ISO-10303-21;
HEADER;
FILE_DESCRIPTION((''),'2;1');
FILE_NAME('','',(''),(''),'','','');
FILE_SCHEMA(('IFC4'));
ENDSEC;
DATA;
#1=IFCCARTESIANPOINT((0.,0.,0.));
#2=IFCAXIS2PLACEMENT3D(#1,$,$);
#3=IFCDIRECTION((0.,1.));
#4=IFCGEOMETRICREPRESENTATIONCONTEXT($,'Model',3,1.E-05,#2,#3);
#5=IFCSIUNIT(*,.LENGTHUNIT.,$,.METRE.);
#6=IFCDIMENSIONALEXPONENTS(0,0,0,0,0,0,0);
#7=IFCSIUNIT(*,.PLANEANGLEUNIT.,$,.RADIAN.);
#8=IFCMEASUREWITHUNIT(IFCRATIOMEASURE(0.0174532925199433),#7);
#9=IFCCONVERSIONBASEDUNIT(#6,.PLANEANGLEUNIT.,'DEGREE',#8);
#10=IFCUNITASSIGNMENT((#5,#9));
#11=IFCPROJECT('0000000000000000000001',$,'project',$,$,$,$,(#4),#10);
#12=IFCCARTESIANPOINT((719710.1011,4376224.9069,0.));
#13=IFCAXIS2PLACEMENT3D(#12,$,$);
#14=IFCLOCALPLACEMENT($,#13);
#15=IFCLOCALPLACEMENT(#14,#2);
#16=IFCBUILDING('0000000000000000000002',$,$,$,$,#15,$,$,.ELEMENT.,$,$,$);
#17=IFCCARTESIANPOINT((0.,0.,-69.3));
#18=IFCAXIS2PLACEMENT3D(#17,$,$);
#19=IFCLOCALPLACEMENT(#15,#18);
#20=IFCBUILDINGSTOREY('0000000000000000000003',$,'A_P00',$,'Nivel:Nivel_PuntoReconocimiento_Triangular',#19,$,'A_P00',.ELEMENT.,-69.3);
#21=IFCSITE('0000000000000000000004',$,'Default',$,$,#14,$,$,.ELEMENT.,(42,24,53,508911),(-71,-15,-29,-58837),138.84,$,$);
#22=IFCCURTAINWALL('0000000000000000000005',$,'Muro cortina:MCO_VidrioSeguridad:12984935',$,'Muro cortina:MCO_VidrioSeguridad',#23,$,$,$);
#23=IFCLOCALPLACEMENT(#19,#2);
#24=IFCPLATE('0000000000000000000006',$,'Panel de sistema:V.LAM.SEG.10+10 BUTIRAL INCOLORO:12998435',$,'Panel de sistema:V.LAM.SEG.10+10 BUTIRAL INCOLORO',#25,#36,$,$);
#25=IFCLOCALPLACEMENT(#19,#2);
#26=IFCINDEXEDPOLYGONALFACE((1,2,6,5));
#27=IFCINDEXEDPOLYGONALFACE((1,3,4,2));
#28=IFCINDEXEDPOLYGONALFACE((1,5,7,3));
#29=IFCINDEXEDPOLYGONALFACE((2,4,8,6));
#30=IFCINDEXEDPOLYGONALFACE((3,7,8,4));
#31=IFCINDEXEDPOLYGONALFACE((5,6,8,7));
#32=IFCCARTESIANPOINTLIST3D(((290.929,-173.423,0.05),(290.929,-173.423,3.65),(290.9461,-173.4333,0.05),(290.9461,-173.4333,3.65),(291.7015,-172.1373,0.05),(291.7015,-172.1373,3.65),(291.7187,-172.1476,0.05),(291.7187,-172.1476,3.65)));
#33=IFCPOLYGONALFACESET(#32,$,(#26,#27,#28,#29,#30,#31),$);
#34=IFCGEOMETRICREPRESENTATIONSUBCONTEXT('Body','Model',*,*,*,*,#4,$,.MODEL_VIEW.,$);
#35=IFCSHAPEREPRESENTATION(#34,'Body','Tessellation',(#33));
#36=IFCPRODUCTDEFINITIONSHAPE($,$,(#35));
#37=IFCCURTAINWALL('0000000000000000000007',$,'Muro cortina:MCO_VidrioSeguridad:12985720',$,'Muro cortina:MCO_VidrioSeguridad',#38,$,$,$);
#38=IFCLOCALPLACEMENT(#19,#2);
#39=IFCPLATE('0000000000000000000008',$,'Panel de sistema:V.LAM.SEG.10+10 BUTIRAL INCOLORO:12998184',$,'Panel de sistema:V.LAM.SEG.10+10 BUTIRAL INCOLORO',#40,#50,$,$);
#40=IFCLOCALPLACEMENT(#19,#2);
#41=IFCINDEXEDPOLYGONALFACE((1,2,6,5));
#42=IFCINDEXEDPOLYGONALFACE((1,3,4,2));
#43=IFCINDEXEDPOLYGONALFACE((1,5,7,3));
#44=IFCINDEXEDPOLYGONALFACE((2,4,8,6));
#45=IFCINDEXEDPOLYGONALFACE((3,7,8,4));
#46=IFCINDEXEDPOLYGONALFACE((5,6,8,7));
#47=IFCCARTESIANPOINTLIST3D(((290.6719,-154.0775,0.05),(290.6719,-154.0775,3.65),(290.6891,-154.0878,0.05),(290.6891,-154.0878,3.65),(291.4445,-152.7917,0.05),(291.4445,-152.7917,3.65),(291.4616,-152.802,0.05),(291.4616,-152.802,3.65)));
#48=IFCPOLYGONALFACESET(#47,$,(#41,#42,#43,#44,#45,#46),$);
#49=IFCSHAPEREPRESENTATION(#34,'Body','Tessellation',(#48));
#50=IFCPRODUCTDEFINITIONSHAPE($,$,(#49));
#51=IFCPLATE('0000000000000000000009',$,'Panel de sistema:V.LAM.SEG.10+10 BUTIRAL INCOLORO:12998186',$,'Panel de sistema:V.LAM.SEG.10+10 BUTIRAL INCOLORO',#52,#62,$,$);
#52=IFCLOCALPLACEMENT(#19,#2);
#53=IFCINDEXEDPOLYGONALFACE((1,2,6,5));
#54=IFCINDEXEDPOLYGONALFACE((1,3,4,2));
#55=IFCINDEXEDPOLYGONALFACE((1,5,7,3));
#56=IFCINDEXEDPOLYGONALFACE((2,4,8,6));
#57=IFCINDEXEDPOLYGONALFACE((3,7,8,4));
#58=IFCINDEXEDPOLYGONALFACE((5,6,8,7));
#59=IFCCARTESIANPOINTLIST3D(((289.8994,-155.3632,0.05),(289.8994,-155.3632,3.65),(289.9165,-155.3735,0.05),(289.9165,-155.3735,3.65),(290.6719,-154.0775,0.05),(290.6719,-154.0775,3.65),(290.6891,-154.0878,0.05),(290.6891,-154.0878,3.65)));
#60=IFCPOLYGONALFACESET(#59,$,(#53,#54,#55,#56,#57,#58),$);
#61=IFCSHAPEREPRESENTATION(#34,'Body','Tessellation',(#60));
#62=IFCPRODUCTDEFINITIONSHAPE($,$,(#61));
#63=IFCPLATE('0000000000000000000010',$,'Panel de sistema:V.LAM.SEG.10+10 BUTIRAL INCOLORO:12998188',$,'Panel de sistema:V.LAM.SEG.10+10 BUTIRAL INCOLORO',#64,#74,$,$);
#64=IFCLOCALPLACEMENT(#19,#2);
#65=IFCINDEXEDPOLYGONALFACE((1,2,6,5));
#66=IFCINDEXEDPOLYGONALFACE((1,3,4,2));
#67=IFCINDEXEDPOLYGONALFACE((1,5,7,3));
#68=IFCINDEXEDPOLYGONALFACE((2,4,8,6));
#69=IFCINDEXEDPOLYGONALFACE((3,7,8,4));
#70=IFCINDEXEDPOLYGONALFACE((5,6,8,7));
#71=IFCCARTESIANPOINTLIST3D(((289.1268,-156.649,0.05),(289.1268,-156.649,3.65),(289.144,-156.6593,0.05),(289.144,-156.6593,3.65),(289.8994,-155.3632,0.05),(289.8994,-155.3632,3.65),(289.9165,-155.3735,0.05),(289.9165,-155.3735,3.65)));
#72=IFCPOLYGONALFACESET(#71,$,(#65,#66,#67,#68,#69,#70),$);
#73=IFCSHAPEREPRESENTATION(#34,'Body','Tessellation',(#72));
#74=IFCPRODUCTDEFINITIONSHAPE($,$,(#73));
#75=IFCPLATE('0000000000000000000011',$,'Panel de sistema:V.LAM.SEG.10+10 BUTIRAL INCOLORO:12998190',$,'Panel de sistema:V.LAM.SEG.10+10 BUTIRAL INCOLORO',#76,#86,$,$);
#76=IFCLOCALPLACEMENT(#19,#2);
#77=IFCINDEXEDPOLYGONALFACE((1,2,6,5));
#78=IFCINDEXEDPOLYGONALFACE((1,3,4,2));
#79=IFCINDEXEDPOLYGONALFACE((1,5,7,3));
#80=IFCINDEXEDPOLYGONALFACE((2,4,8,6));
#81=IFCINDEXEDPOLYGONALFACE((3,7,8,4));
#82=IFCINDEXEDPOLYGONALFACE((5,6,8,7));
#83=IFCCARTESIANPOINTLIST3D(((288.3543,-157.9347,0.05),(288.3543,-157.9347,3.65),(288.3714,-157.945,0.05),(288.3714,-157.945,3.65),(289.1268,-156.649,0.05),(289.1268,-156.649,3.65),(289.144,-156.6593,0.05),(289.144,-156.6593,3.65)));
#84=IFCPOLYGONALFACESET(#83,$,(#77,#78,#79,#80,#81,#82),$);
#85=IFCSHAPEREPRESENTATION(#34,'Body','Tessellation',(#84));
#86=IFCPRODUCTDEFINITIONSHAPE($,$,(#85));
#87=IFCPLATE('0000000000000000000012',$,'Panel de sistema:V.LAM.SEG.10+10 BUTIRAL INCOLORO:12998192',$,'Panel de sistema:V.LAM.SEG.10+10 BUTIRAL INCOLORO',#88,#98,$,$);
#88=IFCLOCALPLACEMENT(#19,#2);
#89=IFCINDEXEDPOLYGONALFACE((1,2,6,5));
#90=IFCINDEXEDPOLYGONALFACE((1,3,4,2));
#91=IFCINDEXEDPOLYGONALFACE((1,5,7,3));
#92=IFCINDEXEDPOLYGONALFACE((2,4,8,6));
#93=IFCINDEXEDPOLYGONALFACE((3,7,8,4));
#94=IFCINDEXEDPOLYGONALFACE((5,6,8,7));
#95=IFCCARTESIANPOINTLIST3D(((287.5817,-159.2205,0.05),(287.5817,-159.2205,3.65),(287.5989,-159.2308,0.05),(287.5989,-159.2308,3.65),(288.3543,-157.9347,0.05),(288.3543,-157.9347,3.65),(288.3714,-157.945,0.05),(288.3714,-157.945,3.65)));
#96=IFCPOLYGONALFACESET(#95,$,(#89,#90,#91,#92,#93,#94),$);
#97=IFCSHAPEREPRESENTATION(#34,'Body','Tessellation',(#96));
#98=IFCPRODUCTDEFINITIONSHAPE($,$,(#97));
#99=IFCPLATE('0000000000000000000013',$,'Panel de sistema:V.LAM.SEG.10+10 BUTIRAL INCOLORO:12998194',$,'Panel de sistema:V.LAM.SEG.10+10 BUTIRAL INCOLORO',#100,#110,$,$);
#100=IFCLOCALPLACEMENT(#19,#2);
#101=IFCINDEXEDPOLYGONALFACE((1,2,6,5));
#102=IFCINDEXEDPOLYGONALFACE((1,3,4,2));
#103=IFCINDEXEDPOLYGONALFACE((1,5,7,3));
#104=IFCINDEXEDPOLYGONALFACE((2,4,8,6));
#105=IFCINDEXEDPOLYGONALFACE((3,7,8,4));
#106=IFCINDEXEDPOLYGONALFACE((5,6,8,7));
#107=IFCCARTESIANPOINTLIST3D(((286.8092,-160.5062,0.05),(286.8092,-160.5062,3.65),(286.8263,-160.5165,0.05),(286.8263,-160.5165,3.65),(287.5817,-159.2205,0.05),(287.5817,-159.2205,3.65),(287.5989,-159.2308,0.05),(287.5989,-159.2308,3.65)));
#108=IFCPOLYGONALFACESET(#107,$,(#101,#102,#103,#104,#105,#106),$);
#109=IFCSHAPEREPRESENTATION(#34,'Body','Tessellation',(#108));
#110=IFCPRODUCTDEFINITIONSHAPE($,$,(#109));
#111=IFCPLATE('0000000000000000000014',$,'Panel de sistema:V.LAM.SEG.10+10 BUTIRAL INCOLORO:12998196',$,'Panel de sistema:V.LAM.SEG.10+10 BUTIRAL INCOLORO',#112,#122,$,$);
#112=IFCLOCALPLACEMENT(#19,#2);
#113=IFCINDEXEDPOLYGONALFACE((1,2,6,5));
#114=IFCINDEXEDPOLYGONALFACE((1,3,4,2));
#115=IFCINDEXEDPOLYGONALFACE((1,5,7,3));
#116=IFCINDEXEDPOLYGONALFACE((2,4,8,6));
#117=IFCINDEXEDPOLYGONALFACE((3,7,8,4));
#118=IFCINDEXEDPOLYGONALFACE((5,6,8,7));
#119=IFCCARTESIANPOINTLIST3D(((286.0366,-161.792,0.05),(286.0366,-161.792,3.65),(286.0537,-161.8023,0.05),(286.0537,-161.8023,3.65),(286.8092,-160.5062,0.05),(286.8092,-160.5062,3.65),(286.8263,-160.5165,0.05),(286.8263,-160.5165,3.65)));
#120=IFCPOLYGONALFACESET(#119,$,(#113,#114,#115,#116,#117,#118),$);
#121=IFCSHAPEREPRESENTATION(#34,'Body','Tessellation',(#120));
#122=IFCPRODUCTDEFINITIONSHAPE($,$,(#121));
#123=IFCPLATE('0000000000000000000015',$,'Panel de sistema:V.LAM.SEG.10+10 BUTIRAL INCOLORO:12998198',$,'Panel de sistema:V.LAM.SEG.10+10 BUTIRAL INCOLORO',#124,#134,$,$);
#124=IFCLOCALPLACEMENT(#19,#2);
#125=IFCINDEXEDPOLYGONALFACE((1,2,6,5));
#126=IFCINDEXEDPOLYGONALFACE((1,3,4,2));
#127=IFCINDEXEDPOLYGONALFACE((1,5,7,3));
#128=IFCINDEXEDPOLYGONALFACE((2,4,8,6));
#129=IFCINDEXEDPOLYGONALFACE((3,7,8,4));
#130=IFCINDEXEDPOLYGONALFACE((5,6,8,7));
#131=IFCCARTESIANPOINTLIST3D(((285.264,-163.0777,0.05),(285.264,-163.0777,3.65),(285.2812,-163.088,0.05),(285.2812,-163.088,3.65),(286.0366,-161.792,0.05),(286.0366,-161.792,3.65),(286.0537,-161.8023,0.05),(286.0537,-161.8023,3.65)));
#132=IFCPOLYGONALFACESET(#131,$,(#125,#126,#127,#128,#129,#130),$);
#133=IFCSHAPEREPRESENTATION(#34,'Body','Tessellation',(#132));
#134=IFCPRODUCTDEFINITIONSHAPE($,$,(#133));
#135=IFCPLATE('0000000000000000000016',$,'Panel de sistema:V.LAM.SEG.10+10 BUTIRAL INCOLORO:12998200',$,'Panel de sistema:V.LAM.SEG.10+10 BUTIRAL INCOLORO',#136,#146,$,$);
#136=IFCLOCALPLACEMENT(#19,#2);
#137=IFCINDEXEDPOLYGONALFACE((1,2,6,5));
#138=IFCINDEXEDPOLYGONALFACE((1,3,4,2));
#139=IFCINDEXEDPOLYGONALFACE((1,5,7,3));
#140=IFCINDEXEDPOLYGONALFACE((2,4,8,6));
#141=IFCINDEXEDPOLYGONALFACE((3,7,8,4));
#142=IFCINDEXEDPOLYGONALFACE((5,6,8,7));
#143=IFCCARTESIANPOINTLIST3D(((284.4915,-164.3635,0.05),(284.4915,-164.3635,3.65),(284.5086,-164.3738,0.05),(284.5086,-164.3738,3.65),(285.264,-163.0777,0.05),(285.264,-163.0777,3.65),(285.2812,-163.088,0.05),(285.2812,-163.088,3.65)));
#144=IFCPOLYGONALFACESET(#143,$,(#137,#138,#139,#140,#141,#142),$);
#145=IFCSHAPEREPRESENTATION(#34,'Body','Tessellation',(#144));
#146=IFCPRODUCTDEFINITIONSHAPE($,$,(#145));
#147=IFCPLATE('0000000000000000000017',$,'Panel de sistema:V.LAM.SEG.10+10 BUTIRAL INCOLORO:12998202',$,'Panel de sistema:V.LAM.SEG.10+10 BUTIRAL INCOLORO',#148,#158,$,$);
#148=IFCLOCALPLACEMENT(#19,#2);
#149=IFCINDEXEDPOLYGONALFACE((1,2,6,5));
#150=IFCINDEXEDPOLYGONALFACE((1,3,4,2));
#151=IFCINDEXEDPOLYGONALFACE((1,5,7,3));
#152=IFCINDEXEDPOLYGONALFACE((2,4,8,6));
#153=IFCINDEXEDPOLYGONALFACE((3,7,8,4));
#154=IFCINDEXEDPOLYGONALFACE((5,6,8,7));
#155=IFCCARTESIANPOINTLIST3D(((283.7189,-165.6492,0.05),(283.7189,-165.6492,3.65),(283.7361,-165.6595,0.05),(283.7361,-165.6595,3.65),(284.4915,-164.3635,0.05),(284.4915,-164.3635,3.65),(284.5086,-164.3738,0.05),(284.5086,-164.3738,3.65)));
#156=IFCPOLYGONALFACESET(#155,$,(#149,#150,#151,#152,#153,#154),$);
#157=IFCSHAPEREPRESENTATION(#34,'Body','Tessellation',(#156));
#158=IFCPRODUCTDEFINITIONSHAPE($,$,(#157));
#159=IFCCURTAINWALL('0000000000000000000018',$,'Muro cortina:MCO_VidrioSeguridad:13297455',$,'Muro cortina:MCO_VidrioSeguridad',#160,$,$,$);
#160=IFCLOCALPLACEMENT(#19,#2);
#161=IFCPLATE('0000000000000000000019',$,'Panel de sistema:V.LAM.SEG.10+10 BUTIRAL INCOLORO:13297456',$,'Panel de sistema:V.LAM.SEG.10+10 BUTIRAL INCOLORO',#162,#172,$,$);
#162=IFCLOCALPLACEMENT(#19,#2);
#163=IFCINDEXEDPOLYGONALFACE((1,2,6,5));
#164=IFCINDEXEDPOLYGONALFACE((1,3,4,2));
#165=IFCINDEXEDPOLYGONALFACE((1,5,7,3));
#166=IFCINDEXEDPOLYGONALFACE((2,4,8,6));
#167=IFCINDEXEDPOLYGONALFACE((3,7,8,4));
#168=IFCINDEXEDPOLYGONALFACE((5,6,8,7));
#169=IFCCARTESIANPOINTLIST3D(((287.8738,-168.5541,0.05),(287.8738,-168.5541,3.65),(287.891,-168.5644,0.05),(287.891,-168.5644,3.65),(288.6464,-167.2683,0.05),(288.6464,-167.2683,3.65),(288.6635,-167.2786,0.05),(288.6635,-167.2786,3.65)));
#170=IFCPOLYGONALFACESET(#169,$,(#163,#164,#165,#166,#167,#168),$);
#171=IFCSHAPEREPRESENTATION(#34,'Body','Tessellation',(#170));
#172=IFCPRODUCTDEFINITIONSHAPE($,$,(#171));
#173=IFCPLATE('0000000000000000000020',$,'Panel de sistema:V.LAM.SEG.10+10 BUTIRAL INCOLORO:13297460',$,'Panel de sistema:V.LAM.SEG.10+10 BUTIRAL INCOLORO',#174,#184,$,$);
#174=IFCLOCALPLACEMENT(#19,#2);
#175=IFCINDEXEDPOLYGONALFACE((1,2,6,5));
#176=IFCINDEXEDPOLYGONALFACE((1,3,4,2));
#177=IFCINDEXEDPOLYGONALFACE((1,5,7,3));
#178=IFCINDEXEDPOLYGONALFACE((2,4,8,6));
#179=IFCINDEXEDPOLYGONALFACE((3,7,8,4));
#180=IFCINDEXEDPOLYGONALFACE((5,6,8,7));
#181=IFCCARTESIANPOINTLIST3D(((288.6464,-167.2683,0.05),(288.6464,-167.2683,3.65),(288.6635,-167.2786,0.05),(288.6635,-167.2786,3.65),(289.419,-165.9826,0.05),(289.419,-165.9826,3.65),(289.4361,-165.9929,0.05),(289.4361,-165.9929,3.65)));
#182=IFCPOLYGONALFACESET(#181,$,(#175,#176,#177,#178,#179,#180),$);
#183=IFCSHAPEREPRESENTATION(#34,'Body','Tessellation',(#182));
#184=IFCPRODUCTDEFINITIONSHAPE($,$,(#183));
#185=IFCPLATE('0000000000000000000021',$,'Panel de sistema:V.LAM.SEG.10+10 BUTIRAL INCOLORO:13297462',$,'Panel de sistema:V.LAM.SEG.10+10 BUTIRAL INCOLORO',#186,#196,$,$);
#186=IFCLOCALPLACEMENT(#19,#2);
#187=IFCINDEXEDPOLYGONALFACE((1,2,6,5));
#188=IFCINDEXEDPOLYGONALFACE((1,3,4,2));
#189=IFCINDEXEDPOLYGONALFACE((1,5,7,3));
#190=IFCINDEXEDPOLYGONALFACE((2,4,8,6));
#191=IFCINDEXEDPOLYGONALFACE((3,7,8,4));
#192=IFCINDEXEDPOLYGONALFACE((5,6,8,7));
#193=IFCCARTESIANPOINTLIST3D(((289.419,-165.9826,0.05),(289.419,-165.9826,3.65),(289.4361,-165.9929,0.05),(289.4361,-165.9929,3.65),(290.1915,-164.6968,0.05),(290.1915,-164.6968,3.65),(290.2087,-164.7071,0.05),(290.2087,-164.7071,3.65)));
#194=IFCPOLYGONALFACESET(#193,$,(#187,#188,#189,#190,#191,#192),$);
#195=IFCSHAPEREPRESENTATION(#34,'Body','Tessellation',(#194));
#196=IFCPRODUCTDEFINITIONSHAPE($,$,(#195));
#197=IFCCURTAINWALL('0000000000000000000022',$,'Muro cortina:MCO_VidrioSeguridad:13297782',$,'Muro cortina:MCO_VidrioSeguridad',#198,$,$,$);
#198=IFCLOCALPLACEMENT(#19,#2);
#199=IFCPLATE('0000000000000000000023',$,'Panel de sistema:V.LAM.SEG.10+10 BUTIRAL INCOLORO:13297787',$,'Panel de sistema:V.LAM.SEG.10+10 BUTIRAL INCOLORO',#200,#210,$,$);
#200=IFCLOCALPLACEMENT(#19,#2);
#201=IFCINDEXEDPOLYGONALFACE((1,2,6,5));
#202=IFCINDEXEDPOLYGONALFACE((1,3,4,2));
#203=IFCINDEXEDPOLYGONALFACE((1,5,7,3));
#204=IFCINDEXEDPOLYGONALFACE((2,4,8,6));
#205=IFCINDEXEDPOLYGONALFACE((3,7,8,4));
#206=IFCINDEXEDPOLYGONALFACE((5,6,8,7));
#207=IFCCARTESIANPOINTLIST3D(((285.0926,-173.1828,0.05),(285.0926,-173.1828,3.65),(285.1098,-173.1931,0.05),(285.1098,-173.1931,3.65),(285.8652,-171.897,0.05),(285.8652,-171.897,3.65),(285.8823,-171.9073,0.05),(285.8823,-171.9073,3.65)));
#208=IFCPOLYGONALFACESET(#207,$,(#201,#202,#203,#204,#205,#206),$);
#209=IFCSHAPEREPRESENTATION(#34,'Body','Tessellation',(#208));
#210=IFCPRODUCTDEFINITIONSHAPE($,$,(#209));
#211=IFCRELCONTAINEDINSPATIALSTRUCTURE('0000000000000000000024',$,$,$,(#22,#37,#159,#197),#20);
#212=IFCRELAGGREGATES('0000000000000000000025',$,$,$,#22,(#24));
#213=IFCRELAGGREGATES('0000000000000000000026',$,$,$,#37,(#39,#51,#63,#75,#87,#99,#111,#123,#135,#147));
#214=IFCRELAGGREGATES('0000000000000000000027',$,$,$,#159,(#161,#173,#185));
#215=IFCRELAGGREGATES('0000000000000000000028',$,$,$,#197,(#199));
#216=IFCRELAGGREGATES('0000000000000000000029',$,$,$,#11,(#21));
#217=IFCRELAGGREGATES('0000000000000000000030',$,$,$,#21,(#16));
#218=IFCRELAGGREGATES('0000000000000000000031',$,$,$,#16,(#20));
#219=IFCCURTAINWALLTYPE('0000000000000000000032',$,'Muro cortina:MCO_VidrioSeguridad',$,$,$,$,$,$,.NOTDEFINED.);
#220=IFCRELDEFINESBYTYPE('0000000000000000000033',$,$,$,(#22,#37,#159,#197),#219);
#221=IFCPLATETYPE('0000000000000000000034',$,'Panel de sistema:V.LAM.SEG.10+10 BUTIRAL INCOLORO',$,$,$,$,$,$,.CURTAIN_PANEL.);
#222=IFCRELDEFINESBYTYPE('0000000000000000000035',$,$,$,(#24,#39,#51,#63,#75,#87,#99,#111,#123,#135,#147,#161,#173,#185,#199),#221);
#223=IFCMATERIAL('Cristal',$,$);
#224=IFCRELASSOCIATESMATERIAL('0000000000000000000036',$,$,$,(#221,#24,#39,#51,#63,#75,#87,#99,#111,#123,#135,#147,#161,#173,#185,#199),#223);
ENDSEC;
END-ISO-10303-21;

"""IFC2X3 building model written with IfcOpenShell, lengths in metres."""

from ifc_helpers import new_model, entity, si_unit, converted_unit, direction, frame, origin, origin_2d_with_axis, place, context, subcontext, project, spatial, rectangle, extrude, source, transform, mapped, material, type_object, type_shapes, element, aggregate, save


model = new_model("IFC2X3")

# Units and contexts
model_context = context("Model", 3, precision=1e-05, world=origin(), true_north=direction((0.0, 1.0)))
body_context = subcontext(model_context, "Body", "Model", "MODEL_VIEW")
ifc_project = project(units=[si_unit("LENGTHUNIT", "METRE"), converted_unit("PLANEANGLEUNIT", "DEGREE", entity("IfcRatioMeasure", 0.0174532925199433), si_unit("PLANEANGLEUNIT", "RADIAN"), dimensions=[0, 0, 0, 0, 0, 0, 0])], contexts=[model_context])

# Site, building, storey
site_placement = place(None, frame((719710.1011, 4376224.9069, 0.0)))
site = spatial("IfcSite", under=ifc_project, at=site_placement, Name="Default", CompositionType="ELEMENT", RefLatitude=(42, 24, 53, 508911), RefLongitude=(-71, -15, -29, -58837), RefElevation=138.84)
building_placement = place(site_placement, origin())
building = spatial("IfcBuilding", under=site, at=building_placement, CompositionType="ELEMENT")
storey_placement = place(building_placement, frame((0.0, 0.0, -69.3)))
storey = spatial("IfcBuildingStorey", under=building, at=storey_placement, Name="A_P00", ObjectType="Nivel:Nivel_PuntoReconocimiento_Triangular", LongName="A_P00", CompositionType="ELEMENT", Elevation=-69.3)

# Curtain wall, plate
curtain_wall_type = type_object("IfcCurtainWallType", Name="Muro cortina:MCO_VidrioSeguridad", PredefinedType="NOTDEFINED")
curtain_wall_1_placement = place(storey_placement, frame((0.0, 0.0, 69.3)))
curtain_wall_1 = element("IfcCurtainWall", 1, at=curtain_wall_1_placement, inside=storey, type_object=curtain_wall_type, Name="Muro cortina:MCO_VidrioSeguridad:12984935", ObjectType="Muro cortina:MCO_VidrioSeguridad")
ifc_material_1 = material(Name="Cristal")
plate_type_1 = type_object("IfcPlateType", Name="Panel de sistema:V.LAM.SEG.10+10 BUTIRAL INCOLORO", PredefinedType="CURTAIN_PANEL", material=ifc_material_1)
shared_shape_1 = source(origin(), body_context, "Body", "SweptSolid", [
    extrude(rectangle(XDim=0.02, YDim=1.5, at=origin_2d_with_axis()), frame((0.0, 0.0, 0.0), z_axis=(0.0, 0.0, 1.0), x_axis=(0.0, 1.0, 0.0)), (0.0, 0.0, 1.0), 3.6),
])
type_shapes(plate_type_1, [shared_shape_1])
plate_1_placement = place(curtain_wall_1_placement, frame((291.3238, -172.7853, -69.25), z_axis=(0.0, 0.0, 1.0), x_axis=(-0.515038, -0.857167, 0.0)))
plate_1 = element("IfcPlate", 2, at=plate_1_placement, type_object=plate_type_1, material=ifc_material_1, Name="Panel de sistema:V.LAM.SEG.10+10 BUTIRAL INCOLORO:12998435", ObjectType="Panel de sistema:V.LAM.SEG.10+10 BUTIRAL INCOLORO", context=body_context, shape_type="MappedRepresentation", body=[
    mapped(shared_shape_1, transform((0.0, 0.0, 0.0), scale=1.0)),
])
aggregate(curtain_wall_1, [plate_1])

# Curtain walls, plates
curtain_wall_2_placement = place(storey_placement, frame((0.0, 0.0, 69.3)))
curtain_wall_2 = element("IfcCurtainWall", 3, at=curtain_wall_2_placement, inside=storey, type_object=curtain_wall_type, Name="Muro cortina:MCO_VidrioSeguridad:12985720", ObjectType="Muro cortina:MCO_VidrioSeguridad")
plate_2_placement = place(curtain_wall_2_placement, frame((291.0668, -153.4397, -69.25), z_axis=(0.0, 0.0, 1.0), x_axis=(-0.515038, -0.857167, 0.0)))
plate_2 = element("IfcPlate", 4, at=plate_2_placement, type_object=plate_type_1, material=ifc_material_1, Name="Panel de sistema:V.LAM.SEG.10+10 BUTIRAL INCOLORO:12998184", ObjectType="Panel de sistema:V.LAM.SEG.10+10 BUTIRAL INCOLORO", context=body_context, shape_type="MappedRepresentation", body=[
    mapped(shared_shape_1, transform((0.0, 0.0, 0.0), scale=1.0)),
])
plate_3_placement = place(curtain_wall_2_placement, frame((290.2942, -154.7255, -69.25), z_axis=(0.0, 0.0, 1.0), x_axis=(-0.515038, -0.857167, 0.0)))
plate_3 = element("IfcPlate", 5, at=plate_3_placement, type_object=plate_type_1, material=ifc_material_1, Name="Panel de sistema:V.LAM.SEG.10+10 BUTIRAL INCOLORO:12998186", ObjectType="Panel de sistema:V.LAM.SEG.10+10 BUTIRAL INCOLORO", context=body_context, shape_type="MappedRepresentation", body=[
    mapped(shared_shape_1, transform((0.0, 0.0, 0.0), scale=1.0)),
])
plate_4_placement = place(curtain_wall_2_placement, frame((289.5217, -156.0112, -69.25), z_axis=(0.0, 0.0, 1.0), x_axis=(-0.515038, -0.857167, 0.0)))
plate_4 = element("IfcPlate", 6, at=plate_4_placement, type_object=plate_type_1, material=ifc_material_1, Name="Panel de sistema:V.LAM.SEG.10+10 BUTIRAL INCOLORO:12998188", ObjectType="Panel de sistema:V.LAM.SEG.10+10 BUTIRAL INCOLORO", context=body_context, shape_type="MappedRepresentation", body=[
    mapped(shared_shape_1, transform((0.0, 0.0, 0.0), scale=1.0)),
])
plate_5_placement = place(curtain_wall_2_placement, frame((288.7491, -157.297, -69.25), z_axis=(0.0, 0.0, 1.0), x_axis=(-0.515038, -0.857167, 0.0)))
plate_5 = element("IfcPlate", 7, at=plate_5_placement, type_object=plate_type_1, material=ifc_material_1, Name="Panel de sistema:V.LAM.SEG.10+10 BUTIRAL INCOLORO:12998190", ObjectType="Panel de sistema:V.LAM.SEG.10+10 BUTIRAL INCOLORO", context=body_context, shape_type="MappedRepresentation", body=[
    mapped(shared_shape_1, transform((0.0, 0.0, 0.0), scale=1.0)),
])
plate_6_placement = place(curtain_wall_2_placement, frame((287.9766, -158.5827, -69.25), z_axis=(0.0, 0.0, 1.0), x_axis=(-0.515038, -0.857167, 0.0)))
plate_6 = element("IfcPlate", 8, at=plate_6_placement, type_object=plate_type_1, material=ifc_material_1, Name="Panel de sistema:V.LAM.SEG.10+10 BUTIRAL INCOLORO:12998192", ObjectType="Panel de sistema:V.LAM.SEG.10+10 BUTIRAL INCOLORO", context=body_context, shape_type="MappedRepresentation", body=[
    mapped(shared_shape_1, transform((0.0, 0.0, 0.0), scale=1.0)),
])
plate_7_placement = place(curtain_wall_2_placement, frame((287.204, -159.8685, -69.25), z_axis=(0.0, 0.0, 1.0), x_axis=(-0.515038, -0.857167, 0.0)))
plate_7 = element("IfcPlate", 9, at=plate_7_placement, type_object=plate_type_1, material=ifc_material_1, Name="Panel de sistema:V.LAM.SEG.10+10 BUTIRAL INCOLORO:12998194", ObjectType="Panel de sistema:V.LAM.SEG.10+10 BUTIRAL INCOLORO", context=body_context, shape_type="MappedRepresentation", body=[
    mapped(shared_shape_1, transform((0.0, 0.0, 0.0), scale=1.0)),
])
plate_8_placement = place(curtain_wall_2_placement, frame((286.4315, -161.1543, -69.25), z_axis=(0.0, 0.0, 1.0), x_axis=(-0.515038, -0.857167, 0.0)))
plate_8 = element("IfcPlate", 10, at=plate_8_placement, type_object=plate_type_1, material=ifc_material_1, Name="Panel de sistema:V.LAM.SEG.10+10 BUTIRAL INCOLORO:12998196", ObjectType="Panel de sistema:V.LAM.SEG.10+10 BUTIRAL INCOLORO", context=body_context, shape_type="MappedRepresentation", body=[
    mapped(shared_shape_1, transform((0.0, 0.0, 0.0), scale=1.0)),
])
plate_9_placement = place(curtain_wall_2_placement, frame((285.6589, -162.44, -69.25), z_axis=(0.0, 0.0, 1.0), x_axis=(-0.515038, -0.857167, 0.0)))
plate_9 = element("IfcPlate", 11, at=plate_9_placement, type_object=plate_type_1, material=ifc_material_1, Name="Panel de sistema:V.LAM.SEG.10+10 BUTIRAL INCOLORO:12998198", ObjectType="Panel de sistema:V.LAM.SEG.10+10 BUTIRAL INCOLORO", context=body_context, shape_type="MappedRepresentation", body=[
    mapped(shared_shape_1, transform((0.0, 0.0, 0.0), scale=1.0)),
])
plate_10_placement = place(curtain_wall_2_placement, frame((284.8863, -163.7258, -69.25), z_axis=(0.0, 0.0, 1.0), x_axis=(-0.515038, -0.857167, 0.0)))
plate_10 = element("IfcPlate", 12, at=plate_10_placement, type_object=plate_type_1, material=ifc_material_1, Name="Panel de sistema:V.LAM.SEG.10+10 BUTIRAL INCOLORO:12998200", ObjectType="Panel de sistema:V.LAM.SEG.10+10 BUTIRAL INCOLORO", context=body_context, shape_type="MappedRepresentation", body=[
    mapped(shared_shape_1, transform((0.0, 0.0, 0.0), scale=1.0)),
])
plate_11_placement = place(curtain_wall_2_placement, frame((284.1138, -165.0115, -69.25), z_axis=(0.0, 0.0, 1.0), x_axis=(-0.515038, -0.857167, 0.0)))
plate_11 = element("IfcPlate", 13, at=plate_11_placement, type_object=plate_type_1, material=ifc_material_1, Name="Panel de sistema:V.LAM.SEG.10+10 BUTIRAL INCOLORO:12998202", ObjectType="Panel de sistema:V.LAM.SEG.10+10 BUTIRAL INCOLORO", context=body_context, shape_type="MappedRepresentation", body=[
    mapped(shared_shape_1, transform((0.0, 0.0, 0.0), scale=1.0)),
])
aggregate(curtain_wall_2, [plate_2, plate_3, plate_4, plate_5, plate_6, plate_7, plate_8, plate_9, plate_10, plate_11])
curtain_wall_3_placement = place(storey_placement, frame((0.0, 0.0, 69.3)))
curtain_wall_3 = element("IfcCurtainWall", 14, at=curtain_wall_3_placement, inside=storey, type_object=curtain_wall_type, Name="Muro cortina:MCO_VidrioSeguridad:13297455", ObjectType="Muro cortina:MCO_VidrioSeguridad")
plate_12_placement = place(curtain_wall_3_placement, frame((288.2687, -167.9164, -69.25), z_axis=(0.0, 0.0, 1.0), x_axis=(0.515038, 0.857167, 0.0)))
plate_12 = element("IfcPlate", 15, at=plate_12_placement, type_object=plate_type_1, material=ifc_material_1, Name="Panel de sistema:V.LAM.SEG.10+10 BUTIRAL INCOLORO:13297456", ObjectType="Panel de sistema:V.LAM.SEG.10+10 BUTIRAL INCOLORO", context=body_context, shape_type="MappedRepresentation", body=[
    mapped(shared_shape_1, transform((0.0, 0.0, 0.0), scale=1.0)),
])
plate_13_placement = place(curtain_wall_3_placement, frame((289.0413, -166.6306, -69.25), z_axis=(0.0, 0.0, 1.0), x_axis=(0.515038, 0.857167, 0.0)))
plate_13 = element("IfcPlate", 16, at=plate_13_placement, type_object=plate_type_1, material=ifc_material_1, Name="Panel de sistema:V.LAM.SEG.10+10 BUTIRAL INCOLORO:13297460", ObjectType="Panel de sistema:V.LAM.SEG.10+10 BUTIRAL INCOLORO", context=body_context, shape_type="MappedRepresentation", body=[
    mapped(shared_shape_1, transform((0.0, 0.0, 0.0), scale=1.0)),
])
plate_14_placement = place(curtain_wall_3_placement, frame((289.8138, -165.3448, -69.25), z_axis=(0.0, 0.0, 1.0), x_axis=(0.515038, 0.857167, 0.0)))
plate_14 = element("IfcPlate", 17, at=plate_14_placement, type_object=plate_type_1, material=ifc_material_1, Name="Panel de sistema:V.LAM.SEG.10+10 BUTIRAL INCOLORO:13297462", ObjectType="Panel de sistema:V.LAM.SEG.10+10 BUTIRAL INCOLORO", context=body_context, shape_type="MappedRepresentation", body=[
    mapped(shared_shape_1, transform((0.0, 0.0, 0.0), scale=1.0)),
])
curtain_wall_4_placement = place(storey_placement, frame((0.0, 0.0, 69.3)))
curtain_wall_4 = element("IfcCurtainWall", 18, at=curtain_wall_4_placement, inside=storey, type_object=curtain_wall_type, Name="Muro cortina:MCO_VidrioSeguridad:13297782", ObjectType="Muro cortina:MCO_VidrioSeguridad")
plate_15_placement = place(curtain_wall_4_placement, frame((285.4875, -172.5451, -69.25), z_axis=(0.0, 0.0, 1.0), x_axis=(0.515038, 0.857167, 0.0)))
plate_15 = element("IfcPlate", 19, at=plate_15_placement, type_object=plate_type_1, material=ifc_material_1, Name="Panel de sistema:V.LAM.SEG.10+10 BUTIRAL INCOLORO:13297787", ObjectType="Panel de sistema:V.LAM.SEG.10+10 BUTIRAL INCOLORO", context=body_context, shape_type="MappedRepresentation", body=[
    mapped(shared_shape_1, transform((0.0, 0.0, 0.0), scale=1.0)),
])

aggregate(curtain_wall_3, [plate_12, plate_13, plate_14])
aggregate(curtain_wall_4, [plate_15])

save(model, "model.ifc")
